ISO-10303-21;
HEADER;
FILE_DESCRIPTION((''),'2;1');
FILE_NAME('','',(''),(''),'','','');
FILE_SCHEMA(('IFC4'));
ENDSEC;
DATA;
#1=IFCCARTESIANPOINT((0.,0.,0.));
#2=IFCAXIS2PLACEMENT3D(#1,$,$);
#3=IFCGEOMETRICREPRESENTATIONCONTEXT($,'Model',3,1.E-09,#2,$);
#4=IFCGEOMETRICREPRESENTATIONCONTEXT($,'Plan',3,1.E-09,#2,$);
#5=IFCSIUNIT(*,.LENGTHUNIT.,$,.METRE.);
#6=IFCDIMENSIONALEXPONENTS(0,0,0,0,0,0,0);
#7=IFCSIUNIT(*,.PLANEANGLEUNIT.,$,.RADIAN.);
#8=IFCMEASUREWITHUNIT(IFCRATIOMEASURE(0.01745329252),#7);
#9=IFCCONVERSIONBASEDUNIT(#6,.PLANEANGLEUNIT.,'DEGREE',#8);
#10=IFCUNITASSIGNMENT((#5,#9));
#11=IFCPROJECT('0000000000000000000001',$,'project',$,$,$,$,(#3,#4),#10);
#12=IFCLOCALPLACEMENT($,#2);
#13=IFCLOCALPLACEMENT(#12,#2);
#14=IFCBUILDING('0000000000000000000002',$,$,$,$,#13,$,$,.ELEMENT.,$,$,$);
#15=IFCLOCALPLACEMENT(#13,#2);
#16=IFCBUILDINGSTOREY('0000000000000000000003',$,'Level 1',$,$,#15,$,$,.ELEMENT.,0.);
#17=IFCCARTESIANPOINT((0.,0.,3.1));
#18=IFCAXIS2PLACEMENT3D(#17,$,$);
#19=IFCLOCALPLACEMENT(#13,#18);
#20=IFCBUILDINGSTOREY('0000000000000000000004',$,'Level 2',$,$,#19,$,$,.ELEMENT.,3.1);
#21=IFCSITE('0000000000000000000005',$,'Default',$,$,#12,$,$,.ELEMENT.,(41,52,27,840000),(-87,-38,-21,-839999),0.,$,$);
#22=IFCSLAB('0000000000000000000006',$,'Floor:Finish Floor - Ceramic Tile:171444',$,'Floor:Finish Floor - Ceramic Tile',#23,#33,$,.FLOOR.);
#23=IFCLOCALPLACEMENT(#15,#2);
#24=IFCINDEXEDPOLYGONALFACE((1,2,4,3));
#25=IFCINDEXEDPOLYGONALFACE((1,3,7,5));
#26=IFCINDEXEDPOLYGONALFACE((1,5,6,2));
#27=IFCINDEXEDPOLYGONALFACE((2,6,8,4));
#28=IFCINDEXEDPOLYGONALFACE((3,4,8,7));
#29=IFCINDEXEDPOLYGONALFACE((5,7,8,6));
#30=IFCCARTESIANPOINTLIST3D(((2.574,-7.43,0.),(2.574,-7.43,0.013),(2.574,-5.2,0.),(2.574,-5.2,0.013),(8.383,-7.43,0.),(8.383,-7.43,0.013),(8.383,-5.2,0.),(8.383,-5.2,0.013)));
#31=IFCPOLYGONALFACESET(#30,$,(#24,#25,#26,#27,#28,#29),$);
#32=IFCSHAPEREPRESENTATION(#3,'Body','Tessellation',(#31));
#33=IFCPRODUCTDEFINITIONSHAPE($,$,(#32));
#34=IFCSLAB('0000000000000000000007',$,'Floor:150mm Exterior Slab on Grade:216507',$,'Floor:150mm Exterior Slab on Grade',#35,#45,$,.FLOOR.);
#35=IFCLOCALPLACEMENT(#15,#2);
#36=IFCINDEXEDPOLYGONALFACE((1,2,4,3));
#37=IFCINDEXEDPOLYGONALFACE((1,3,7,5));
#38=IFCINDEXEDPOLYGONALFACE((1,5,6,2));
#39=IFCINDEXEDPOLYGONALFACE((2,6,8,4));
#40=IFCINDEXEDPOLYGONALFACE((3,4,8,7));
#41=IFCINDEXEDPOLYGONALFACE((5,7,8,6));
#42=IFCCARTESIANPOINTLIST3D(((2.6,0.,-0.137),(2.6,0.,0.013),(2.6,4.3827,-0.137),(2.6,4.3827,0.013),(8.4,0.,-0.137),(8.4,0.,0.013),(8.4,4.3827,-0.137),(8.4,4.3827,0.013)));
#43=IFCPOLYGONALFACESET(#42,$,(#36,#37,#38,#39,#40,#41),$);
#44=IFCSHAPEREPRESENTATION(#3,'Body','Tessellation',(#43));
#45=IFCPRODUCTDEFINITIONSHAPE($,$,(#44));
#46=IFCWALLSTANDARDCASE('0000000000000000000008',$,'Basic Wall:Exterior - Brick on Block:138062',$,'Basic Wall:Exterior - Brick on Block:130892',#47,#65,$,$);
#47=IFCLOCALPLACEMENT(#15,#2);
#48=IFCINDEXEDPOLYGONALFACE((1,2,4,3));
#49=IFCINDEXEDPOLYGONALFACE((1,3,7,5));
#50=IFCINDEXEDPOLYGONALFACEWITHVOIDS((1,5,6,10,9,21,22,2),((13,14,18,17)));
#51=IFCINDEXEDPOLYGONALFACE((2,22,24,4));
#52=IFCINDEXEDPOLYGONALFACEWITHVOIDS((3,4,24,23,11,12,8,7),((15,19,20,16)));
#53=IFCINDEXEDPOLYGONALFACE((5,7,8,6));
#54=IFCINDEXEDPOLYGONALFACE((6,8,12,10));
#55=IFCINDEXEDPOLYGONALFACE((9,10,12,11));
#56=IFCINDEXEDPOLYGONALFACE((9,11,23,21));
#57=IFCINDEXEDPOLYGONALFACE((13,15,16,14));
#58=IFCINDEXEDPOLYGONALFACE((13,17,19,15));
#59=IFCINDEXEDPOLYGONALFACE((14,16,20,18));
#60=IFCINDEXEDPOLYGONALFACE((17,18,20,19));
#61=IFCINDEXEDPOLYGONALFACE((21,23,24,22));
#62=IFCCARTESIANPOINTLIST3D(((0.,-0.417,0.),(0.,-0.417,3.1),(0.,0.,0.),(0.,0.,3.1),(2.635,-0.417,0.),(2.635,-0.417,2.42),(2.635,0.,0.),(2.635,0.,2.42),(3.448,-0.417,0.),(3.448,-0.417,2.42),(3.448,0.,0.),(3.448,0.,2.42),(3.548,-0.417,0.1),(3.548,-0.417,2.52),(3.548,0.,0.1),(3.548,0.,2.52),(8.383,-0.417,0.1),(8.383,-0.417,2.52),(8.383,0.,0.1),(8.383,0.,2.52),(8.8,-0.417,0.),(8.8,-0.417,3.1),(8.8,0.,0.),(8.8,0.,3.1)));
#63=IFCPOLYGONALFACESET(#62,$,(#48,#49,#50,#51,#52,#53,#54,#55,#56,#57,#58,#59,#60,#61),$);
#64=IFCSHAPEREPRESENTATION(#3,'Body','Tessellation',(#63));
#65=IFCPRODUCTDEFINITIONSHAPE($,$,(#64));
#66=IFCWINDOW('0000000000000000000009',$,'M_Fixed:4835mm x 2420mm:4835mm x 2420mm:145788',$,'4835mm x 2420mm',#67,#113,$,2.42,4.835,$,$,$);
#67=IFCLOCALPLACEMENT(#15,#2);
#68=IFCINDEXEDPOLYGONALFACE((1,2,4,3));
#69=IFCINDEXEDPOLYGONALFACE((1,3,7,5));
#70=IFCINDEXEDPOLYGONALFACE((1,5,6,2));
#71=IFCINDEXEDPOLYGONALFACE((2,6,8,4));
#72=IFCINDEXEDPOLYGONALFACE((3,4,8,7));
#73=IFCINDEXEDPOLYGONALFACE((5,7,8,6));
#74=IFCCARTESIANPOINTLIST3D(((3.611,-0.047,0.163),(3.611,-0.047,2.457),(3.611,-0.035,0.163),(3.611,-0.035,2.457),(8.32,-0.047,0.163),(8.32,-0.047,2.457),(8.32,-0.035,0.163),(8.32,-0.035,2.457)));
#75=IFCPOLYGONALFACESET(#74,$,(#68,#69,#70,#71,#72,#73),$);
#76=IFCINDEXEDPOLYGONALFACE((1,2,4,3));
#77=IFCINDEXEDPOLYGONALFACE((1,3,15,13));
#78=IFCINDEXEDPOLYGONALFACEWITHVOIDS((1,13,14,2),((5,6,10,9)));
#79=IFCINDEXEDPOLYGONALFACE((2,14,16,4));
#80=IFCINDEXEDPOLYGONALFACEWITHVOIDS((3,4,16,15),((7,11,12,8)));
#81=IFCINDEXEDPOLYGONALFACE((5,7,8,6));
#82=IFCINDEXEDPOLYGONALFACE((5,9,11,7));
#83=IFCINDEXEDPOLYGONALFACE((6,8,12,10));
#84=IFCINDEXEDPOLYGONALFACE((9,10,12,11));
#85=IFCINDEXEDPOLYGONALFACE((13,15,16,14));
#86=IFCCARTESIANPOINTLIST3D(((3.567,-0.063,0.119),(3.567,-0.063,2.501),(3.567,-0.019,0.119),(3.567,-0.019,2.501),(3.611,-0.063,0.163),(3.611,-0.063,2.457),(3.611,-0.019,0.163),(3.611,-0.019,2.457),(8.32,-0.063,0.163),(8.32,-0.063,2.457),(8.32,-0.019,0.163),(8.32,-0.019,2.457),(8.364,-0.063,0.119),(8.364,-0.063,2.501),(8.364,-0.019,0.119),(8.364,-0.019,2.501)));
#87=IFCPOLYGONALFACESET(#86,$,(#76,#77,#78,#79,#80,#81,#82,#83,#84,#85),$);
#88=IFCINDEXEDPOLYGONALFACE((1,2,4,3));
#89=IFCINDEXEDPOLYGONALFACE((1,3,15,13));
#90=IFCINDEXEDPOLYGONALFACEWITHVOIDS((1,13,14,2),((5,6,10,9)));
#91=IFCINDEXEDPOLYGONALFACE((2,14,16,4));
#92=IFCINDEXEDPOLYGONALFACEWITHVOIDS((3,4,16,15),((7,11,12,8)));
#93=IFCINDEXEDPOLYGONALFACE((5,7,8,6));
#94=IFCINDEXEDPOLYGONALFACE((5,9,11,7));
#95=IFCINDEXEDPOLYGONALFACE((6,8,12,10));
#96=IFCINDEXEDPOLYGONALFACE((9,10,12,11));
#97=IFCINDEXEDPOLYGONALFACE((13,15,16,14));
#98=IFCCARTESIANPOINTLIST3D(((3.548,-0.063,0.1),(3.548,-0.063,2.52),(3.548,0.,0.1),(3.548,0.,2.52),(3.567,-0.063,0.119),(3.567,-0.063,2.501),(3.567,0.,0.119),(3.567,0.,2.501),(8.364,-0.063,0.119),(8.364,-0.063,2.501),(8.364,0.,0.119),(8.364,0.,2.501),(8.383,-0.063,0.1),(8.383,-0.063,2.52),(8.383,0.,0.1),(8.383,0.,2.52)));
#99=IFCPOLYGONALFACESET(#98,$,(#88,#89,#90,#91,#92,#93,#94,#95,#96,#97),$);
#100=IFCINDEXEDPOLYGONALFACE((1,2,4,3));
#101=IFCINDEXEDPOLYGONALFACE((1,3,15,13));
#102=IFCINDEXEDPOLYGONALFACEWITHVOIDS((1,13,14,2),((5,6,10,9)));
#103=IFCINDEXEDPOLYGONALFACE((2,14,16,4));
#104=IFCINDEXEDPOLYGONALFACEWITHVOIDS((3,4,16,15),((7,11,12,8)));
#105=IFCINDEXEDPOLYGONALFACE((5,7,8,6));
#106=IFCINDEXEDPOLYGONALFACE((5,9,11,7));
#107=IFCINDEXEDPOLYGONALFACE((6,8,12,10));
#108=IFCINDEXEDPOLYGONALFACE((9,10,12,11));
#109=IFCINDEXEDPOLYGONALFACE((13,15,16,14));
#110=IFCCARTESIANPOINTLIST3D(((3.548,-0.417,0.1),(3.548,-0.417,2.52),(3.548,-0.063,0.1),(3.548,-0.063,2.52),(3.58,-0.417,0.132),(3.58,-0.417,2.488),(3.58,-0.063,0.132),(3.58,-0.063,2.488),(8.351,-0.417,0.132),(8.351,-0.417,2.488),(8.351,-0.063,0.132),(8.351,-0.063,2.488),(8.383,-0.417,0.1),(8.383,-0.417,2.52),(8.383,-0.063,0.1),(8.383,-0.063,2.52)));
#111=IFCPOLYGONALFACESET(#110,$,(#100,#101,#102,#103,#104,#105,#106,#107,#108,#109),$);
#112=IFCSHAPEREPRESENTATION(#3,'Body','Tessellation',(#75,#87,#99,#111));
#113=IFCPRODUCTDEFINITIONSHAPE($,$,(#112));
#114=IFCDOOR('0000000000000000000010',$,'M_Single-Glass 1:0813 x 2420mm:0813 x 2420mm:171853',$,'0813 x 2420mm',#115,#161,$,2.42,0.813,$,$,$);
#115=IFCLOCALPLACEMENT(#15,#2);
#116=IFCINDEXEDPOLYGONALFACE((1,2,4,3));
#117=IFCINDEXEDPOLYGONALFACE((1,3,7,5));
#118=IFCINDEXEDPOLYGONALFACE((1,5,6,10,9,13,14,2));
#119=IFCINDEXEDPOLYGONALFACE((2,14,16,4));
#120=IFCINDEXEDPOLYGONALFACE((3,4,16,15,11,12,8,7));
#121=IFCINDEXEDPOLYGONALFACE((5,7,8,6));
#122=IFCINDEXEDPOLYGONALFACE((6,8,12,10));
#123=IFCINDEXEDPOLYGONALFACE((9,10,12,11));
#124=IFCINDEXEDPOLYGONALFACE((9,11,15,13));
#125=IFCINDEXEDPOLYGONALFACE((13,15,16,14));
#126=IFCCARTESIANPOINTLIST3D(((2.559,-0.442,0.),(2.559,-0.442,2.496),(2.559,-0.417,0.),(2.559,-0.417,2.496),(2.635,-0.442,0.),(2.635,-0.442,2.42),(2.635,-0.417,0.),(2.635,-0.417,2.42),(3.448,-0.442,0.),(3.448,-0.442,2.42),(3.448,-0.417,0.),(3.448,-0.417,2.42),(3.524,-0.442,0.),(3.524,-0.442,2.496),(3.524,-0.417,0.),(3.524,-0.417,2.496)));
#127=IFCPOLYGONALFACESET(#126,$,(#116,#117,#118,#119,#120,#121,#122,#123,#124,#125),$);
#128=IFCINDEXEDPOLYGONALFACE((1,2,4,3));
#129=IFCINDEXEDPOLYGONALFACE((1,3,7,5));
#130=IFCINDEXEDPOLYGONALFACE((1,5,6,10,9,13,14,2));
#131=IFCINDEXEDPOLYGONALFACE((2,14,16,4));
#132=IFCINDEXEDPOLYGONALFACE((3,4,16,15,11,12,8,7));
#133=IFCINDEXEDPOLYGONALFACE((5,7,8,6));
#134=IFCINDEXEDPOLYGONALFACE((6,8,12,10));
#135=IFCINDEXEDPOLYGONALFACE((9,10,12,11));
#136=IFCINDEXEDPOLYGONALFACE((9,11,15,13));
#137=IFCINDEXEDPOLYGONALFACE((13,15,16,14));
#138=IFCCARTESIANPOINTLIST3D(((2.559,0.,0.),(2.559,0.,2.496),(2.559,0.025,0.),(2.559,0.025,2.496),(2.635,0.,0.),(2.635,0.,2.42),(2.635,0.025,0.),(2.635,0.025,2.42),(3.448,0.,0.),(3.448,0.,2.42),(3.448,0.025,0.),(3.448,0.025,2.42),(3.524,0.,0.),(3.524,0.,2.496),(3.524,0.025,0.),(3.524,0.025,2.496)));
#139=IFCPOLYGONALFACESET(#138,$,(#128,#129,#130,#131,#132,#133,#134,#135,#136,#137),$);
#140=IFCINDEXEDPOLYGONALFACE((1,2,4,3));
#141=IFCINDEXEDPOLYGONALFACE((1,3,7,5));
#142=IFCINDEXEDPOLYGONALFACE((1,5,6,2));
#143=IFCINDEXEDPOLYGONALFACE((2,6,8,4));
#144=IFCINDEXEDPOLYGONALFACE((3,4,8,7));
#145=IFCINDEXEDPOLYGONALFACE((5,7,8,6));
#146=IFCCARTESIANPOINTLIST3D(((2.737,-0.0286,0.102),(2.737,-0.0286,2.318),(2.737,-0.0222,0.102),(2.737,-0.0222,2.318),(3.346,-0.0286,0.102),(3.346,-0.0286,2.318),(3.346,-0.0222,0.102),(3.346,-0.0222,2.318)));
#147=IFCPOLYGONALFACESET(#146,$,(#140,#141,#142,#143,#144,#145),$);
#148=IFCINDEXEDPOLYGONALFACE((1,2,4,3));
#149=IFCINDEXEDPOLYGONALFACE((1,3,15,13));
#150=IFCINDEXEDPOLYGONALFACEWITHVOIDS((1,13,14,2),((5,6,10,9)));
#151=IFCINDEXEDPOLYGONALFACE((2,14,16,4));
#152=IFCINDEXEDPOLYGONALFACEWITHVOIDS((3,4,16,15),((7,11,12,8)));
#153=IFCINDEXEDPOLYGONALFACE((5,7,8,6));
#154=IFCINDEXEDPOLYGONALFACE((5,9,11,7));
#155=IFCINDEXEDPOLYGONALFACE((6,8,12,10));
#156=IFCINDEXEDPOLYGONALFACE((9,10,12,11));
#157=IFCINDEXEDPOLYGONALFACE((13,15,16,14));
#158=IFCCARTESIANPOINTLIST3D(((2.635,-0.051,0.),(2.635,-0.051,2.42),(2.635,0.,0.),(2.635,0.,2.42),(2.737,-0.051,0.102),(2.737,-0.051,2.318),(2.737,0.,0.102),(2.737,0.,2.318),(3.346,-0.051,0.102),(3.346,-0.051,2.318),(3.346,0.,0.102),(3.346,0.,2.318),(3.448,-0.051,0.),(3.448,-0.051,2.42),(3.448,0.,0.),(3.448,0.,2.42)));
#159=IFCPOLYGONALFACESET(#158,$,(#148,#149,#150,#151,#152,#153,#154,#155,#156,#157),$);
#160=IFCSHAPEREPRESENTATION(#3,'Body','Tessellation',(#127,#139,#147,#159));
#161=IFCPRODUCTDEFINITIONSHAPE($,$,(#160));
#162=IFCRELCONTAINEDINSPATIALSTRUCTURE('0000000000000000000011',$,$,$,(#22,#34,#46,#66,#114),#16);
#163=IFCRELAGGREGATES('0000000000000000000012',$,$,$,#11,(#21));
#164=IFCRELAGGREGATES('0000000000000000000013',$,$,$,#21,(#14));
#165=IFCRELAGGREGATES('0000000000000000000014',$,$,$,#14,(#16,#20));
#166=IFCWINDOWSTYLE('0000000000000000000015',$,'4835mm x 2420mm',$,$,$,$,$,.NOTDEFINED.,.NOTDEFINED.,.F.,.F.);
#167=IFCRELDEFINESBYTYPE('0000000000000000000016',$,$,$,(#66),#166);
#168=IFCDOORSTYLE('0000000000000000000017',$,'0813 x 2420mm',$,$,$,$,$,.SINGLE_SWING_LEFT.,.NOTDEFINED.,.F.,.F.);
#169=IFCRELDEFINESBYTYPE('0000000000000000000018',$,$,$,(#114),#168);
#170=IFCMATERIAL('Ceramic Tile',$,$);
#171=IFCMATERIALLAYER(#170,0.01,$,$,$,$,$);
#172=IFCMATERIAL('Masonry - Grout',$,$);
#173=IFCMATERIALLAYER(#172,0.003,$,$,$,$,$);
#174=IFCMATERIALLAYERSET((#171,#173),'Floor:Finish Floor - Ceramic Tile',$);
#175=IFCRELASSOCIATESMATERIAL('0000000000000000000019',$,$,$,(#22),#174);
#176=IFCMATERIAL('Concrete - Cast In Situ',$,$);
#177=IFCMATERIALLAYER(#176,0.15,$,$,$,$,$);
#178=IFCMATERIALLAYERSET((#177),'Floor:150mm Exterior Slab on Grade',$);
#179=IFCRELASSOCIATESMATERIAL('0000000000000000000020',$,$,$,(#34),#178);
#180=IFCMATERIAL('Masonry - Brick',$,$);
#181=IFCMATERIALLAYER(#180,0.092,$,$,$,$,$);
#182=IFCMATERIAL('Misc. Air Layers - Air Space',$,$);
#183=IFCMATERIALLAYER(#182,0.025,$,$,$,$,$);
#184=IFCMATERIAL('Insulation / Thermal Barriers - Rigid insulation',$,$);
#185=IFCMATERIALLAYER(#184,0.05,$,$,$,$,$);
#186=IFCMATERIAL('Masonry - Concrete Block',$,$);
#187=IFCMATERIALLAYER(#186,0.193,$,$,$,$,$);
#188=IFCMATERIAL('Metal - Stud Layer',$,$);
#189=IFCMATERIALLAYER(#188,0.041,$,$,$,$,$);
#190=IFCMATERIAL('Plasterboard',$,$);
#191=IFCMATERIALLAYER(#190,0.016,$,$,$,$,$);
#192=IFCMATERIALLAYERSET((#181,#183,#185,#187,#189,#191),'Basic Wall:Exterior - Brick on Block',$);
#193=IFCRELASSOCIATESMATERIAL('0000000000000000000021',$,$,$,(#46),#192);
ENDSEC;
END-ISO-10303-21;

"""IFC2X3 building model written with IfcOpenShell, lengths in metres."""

from ifc_helpers import new_model, entity, si_unit, converted_unit, frame, frame_2d, origin, origin_2d_with_axis, place, context, project, spatial, polyline, rectangle, outline, extrude, source, transform, mapped, material, layer, layer_set, layer_usage, type_object, type_shapes, element, fill, save


model = new_model("IFC2X3")

# Units and contexts
model_context = context("Model", 3, precision=1e-09, world=origin())
plan_context = context("Plan", 3, precision=1e-09, world=origin())
ifc_project = project(units=[si_unit("LENGTHUNIT", "METRE"), converted_unit("PLANEANGLEUNIT", "DEGREE", entity("IfcRatioMeasure", 0.01745329252), si_unit("PLANEANGLEUNIT", "RADIAN"), dimensions=[0, 0, 0, 0, 0, 0, 0])], contexts=[model_context, plan_context])

# Site, building, storey
site_placement = place(None, origin())
site = spatial("IfcSite", under=ifc_project, at=site_placement, Name="Default", CompositionType="ELEMENT", RefLatitude=(41, 52, 27, 840000), RefLongitude=(-87, -38, -21, -839999), RefElevation=0.0)
building_placement = place(site_placement, origin())
building = spatial("IfcBuilding", under=site, at=building_placement, CompositionType="ELEMENT")
storey_1_placement = place(building_placement, origin())
storey_1 = spatial("IfcBuildingStorey", under=building, at=storey_1_placement, Name="Level 1", CompositionType="ELEMENT", Elevation=0.0)

# Slabs
ifc_material_1 = material(Name="Ceramic Tile")
ifc_layer_1 = layer(ifc_material_1, 0.01)
ifc_material_2 = material(Name="Masonry - Grout")
ifc_layer_2 = layer(ifc_material_2, 0.003)
ifc_layer_set_1 = layer_set([ifc_layer_1, ifc_layer_2], Name="Floor:Finish Floor - Ceramic Tile")
ifc_layer_usage_1 = layer_usage(ifc_layer_set_1, "AXIS3", "POSITIVE", 0.0)
slab_1_placement = place(storey_1_placement, frame((2.574, -7.43, 0.0)))
element("IfcSlab", 1, at=slab_1_placement, inside=storey_1, material=ifc_layer_usage_1, Name="Floor:Finish Floor - Ceramic Tile:171444", ObjectType="Floor:Finish Floor - Ceramic Tile", PredefinedType="FLOOR", context=model_context, shape_type="SweptSolid", body=[
    extrude(rectangle(XDim=5.809, YDim=2.23, at=frame_2d((0.0, 0.0), x_axis=(-1.0, 0.0))), frame((2.9045, 1.115, 0.013), z_axis=(0.0, 0.0, -1.0), x_axis=(-1.0, 0.0, 0.0)), (0.0, 0.0, 1.0), 0.013),
])
ifc_material_3 = material(Name="Concrete - Cast In Situ")
ifc_layer_3 = layer(ifc_material_3, 0.15)
ifc_layer_set_2 = layer_set([ifc_layer_3], Name="Floor:150mm Exterior Slab on Grade")
ifc_layer_usage_2 = layer_usage(ifc_layer_set_2, "AXIS3", "POSITIVE", 0.0)
slab_2_placement = place(storey_1_placement, frame((2.6, 0.0, -0.137)))
element("IfcSlab", 2, at=slab_2_placement, inside=storey_1, material=ifc_layer_usage_2, Name="Floor:150mm Exterior Slab on Grade:216507", ObjectType="Floor:150mm Exterior Slab on Grade", PredefinedType="FLOOR", context=model_context, shape_type="SweptSolid", body=[
    extrude(rectangle(XDim=5.8, YDim=4.3827, at=frame_2d((0.0, 0.0), x_axis=(-1.0, 0.0))), frame((2.9, 2.1914, 0.15), z_axis=(0.0, 0.0, -1.0), x_axis=(-1.0, 0.0, 0.0)), (0.0, 0.0, 1.0), 0.15),
])

# Wall, openings, window, door
ifc_material_4 = material(Name="Masonry - Brick")
ifc_layer_4 = layer(ifc_material_4, 0.092)
ifc_material_5 = material(Name="Misc. Air Layers - Air Space")
ifc_layer_5 = layer(ifc_material_5, 0.025)
ifc_material_6 = material(Name="Insulation / Thermal Barriers - Rigid insulation")
ifc_layer_6 = layer(ifc_material_6, 0.05)
ifc_material_7 = material(Name="Masonry - Concrete Block")
ifc_layer_7 = layer(ifc_material_7, 0.193)
ifc_material_8 = material(Name="Metal - Stud Layer")
ifc_layer_8 = layer(ifc_material_8, 0.041)
ifc_material_9 = material(Name="Plasterboard")
ifc_layer_9 = layer(ifc_material_9, 0.016)
ifc_layer_set_3 = layer_set([ifc_layer_4, ifc_layer_5, ifc_layer_6, ifc_layer_7, ifc_layer_8, ifc_layer_9], Name="Basic Wall:Exterior - Brick on Block")
ifc_layer_usage_3 = layer_usage(ifc_layer_set_3, "AXIS2", "NEGATIVE", 0.2085)
wall_1_placement = place(storey_1_placement, frame((0.0, -0.2085, 0.0)))
wall_1 = element("IfcWallStandardCase", 3, at=wall_1_placement, inside=storey_1, material=ifc_layer_usage_3, Name="Basic Wall:Exterior - Brick on Block:138062", ObjectType="Basic Wall:Exterior - Brick on Block:130892", context=model_context, shape_type="SweptSolid", body=[
    extrude(rectangle(XDim=8.8, YDim=0.417, at=frame_2d((4.4, 0.0), x_axis=(-1.0, 0.0))), origin(), (0.0, 0.0, 1.0), 3.1),
])
opening_1_placement = place(wall_1_placement, frame((3.548, -0.2085, 0.1)))
opening_1 = element("IfcOpeningElement", 4, at=opening_1_placement, cuts=wall_1, ObjectType="Opening", context=model_context, shape_type="SweptSolid", body=[
    extrude(rectangle(XDim=2.42, YDim=4.835, at=frame_2d((1.21, 2.4175), x_axis=(1.0, 0.0))), frame((0.0, 0.0, 0.0), z_axis=(0.0, 1.0, 0.0), x_axis=(0.0, 0.0, 1.0)), (0.0, 0.0, 1.0), 0.417),
])
opening_2_placement = place(wall_1_placement, frame((2.635, -0.2085, 0.0)))
opening_2 = element("IfcOpeningElement", 5, at=opening_2_placement, cuts=wall_1, ObjectType="Opening", context=model_context, shape_type="SweptSolid", body=[
    extrude(rectangle(XDim=0.813, YDim=2.42, at=frame_2d((1.21, 0.4065), x_axis=(0.0, -1.0))), frame((0.0, 0.0, 0.0), z_axis=(0.0, 1.0, 0.0), x_axis=(0.0, 0.0, 1.0)), (0.0, 0.0, 1.0), 0.417),
])
window_style_1 = type_object("IfcWindowStyle", Name="4835mm x 2420mm", ConstructionType="NOTDEFINED", OperationType="NOTDEFINED", ParameterTakesPrecedence=False, Sizeable=False)
shared_shape_1 = source(origin(), model_context, "Body", "SweptSolid", [
    extrude(rectangle(XDim=0.012, YDim=4.709, at=origin_2d_with_axis()), frame((2.4175, 0.376, 0.063), z_axis=(0.0, 0.0, 1.0), x_axis=(0.0, -1.0, 0.0)), (0.0, 0.0, 1.0), 2.294),
    extrude(outline(polyline([(-2.3985, -1.191), (2.3985, -1.191), (2.3985, 1.191), (-2.3985, 1.191), (-2.3985, -1.191)]), holes=[polyline([(-2.3545, -1.147), (-2.3545, 1.147), (2.3545, 1.147), (2.3545, -1.147), (-2.3545, -1.147)])]), frame((2.4175, 0.354, 1.21), z_axis=(0.0, 1.0, 0.0), x_axis=(1.0, 0.0, 0.0)), (0.0, 0.0, 1.0), 0.044),
    extrude(outline(polyline([(-2.4175, -1.21), (2.4175, -1.21), (2.4175, 1.21), (-2.4175, 1.21), (-2.4175, -1.21)]), holes=[polyline([(-2.3985, -1.191), (-2.3985, 1.191), (2.3985, 1.191), (2.3985, -1.191), (-2.3985, -1.191)])]), frame((2.4175, 0.354, 1.21), z_axis=(0.0, 1.0, 0.0), x_axis=(1.0, 0.0, 0.0)), (0.0, 0.0, 1.0), 0.063),
    extrude(outline(polyline([(-2.4175, -1.21), (2.4175, -1.21), (2.4175, 1.21), (-2.4175, 1.21), (-2.4175, -1.21)]), holes=[polyline([(-2.3855, -1.178), (-2.3855, 1.178), (2.3855, 1.178), (2.3855, -1.178), (-2.3855, -1.178)])]), frame((2.4175, 0.0, 1.21), z_axis=(0.0, 1.0, 0.0), x_axis=(1.0, 0.0, 0.0)), (0.0, 0.0, 1.0), 0.354),
])
type_shapes(window_style_1, [shared_shape_1])
window_1_placement = place(opening_1_placement, origin())
window_1 = element("IfcWindow", 6, at=window_1_placement, inside=storey_1, type_object=window_style_1, Name="M_Fixed:4835mm x 2420mm:4835mm x 2420mm:145788", ObjectType="4835mm x 2420mm", OverallHeight=2.42, OverallWidth=4.835, context=model_context, shape_type="MappedRepresentation", body=[
    mapped(shared_shape_1, transform((0.0, 0.0, 0.0), scale=1.0)),
])
fill(opening_1, window_1)
door_style_1 = type_object("IfcDoorStyle", Name="0813 x 2420mm", ConstructionType="NOTDEFINED", OperationType="SINGLE_SWING_LEFT", ParameterTakesPrecedence=False, Sizeable=False)
shared_shape_2 = source(origin(), model_context, "Body", "SweptSolid", [
    extrude(outline(polyline([(-0.4065, -1.191), (-0.4065, 1.229), (-0.4825, 1.229), (-0.4825, -1.267), (0.4825, -1.267), (0.4825, 1.229), (0.4065, 1.229), (0.4065, -1.191), (-0.4065, -1.191)])), frame((0.4065, 0.0, 1.229), z_axis=(0.0, 1.0, 0.0), x_axis=(1.0, 0.0, 0.0)), (0.0, 0.0, -1.0), 0.025),
    extrude(outline(polyline([(-0.4065, -1.191), (-0.4065, 1.229), (-0.4825, 1.229), (-0.4825, -1.267), (0.4825, -1.267), (0.4825, 1.229), (0.4065, 1.229), (0.4065, -1.191), (-0.4065, -1.191)])), frame((0.4065, 0.442, 1.229), z_axis=(0.0, 1.0, 0.0), x_axis=(1.0, 0.0, 0.0)), (0.0, 0.0, -1.0), 0.025),
    extrude(rectangle(XDim=0.609, YDim=0.0063, at=origin_2d_with_axis()), frame((0.4065, 0.3916, 0.102)), (0.0, 0.0, 1.0), 2.216),
    extrude(outline(polyline([(-1.21, -0.4065), (1.21, -0.4065), (1.21, 0.4065), (-1.21, 0.4065), (-1.21, -0.4065)]), holes=[polyline([(-1.108, 0.3045), (1.108, 0.3045), (1.108, -0.3045), (-1.108, -0.3045), (-1.108, 0.3045)])]), frame((0.4065, 0.417, 1.21), z_axis=(0.0, -1.0, 0.0), x_axis=(0.0, 0.0, -1.0)), (0.0, 0.0, 1.0), 0.051),
])
type_shapes(door_style_1, [shared_shape_2])
door_1_placement = place(opening_2_placement, origin())
door_1 = element("IfcDoor", 7, at=door_1_placement, inside=storey_1, type_object=door_style_1, Name="M_Single-Glass 1:0813 x 2420mm:0813 x 2420mm:171853", ObjectType="0813 x 2420mm", OverallHeight=2.42, OverallWidth=0.813, context=model_context, shape_type="MappedRepresentation", body=[
    mapped(shared_shape_2, transform((0.0, 0.0, 0.0), scale=1.0)),
])
fill(opening_2, door_1)

# Shared definitions
storey_2_placement = place(building_placement, frame((0.0, 0.0, 3.1)))
storey_2 = spatial("IfcBuildingStorey", under=building, at=storey_2_placement, Name="Level 2", CompositionType="ELEMENT", Elevation=3.1)

save(model, "model.ifc")
